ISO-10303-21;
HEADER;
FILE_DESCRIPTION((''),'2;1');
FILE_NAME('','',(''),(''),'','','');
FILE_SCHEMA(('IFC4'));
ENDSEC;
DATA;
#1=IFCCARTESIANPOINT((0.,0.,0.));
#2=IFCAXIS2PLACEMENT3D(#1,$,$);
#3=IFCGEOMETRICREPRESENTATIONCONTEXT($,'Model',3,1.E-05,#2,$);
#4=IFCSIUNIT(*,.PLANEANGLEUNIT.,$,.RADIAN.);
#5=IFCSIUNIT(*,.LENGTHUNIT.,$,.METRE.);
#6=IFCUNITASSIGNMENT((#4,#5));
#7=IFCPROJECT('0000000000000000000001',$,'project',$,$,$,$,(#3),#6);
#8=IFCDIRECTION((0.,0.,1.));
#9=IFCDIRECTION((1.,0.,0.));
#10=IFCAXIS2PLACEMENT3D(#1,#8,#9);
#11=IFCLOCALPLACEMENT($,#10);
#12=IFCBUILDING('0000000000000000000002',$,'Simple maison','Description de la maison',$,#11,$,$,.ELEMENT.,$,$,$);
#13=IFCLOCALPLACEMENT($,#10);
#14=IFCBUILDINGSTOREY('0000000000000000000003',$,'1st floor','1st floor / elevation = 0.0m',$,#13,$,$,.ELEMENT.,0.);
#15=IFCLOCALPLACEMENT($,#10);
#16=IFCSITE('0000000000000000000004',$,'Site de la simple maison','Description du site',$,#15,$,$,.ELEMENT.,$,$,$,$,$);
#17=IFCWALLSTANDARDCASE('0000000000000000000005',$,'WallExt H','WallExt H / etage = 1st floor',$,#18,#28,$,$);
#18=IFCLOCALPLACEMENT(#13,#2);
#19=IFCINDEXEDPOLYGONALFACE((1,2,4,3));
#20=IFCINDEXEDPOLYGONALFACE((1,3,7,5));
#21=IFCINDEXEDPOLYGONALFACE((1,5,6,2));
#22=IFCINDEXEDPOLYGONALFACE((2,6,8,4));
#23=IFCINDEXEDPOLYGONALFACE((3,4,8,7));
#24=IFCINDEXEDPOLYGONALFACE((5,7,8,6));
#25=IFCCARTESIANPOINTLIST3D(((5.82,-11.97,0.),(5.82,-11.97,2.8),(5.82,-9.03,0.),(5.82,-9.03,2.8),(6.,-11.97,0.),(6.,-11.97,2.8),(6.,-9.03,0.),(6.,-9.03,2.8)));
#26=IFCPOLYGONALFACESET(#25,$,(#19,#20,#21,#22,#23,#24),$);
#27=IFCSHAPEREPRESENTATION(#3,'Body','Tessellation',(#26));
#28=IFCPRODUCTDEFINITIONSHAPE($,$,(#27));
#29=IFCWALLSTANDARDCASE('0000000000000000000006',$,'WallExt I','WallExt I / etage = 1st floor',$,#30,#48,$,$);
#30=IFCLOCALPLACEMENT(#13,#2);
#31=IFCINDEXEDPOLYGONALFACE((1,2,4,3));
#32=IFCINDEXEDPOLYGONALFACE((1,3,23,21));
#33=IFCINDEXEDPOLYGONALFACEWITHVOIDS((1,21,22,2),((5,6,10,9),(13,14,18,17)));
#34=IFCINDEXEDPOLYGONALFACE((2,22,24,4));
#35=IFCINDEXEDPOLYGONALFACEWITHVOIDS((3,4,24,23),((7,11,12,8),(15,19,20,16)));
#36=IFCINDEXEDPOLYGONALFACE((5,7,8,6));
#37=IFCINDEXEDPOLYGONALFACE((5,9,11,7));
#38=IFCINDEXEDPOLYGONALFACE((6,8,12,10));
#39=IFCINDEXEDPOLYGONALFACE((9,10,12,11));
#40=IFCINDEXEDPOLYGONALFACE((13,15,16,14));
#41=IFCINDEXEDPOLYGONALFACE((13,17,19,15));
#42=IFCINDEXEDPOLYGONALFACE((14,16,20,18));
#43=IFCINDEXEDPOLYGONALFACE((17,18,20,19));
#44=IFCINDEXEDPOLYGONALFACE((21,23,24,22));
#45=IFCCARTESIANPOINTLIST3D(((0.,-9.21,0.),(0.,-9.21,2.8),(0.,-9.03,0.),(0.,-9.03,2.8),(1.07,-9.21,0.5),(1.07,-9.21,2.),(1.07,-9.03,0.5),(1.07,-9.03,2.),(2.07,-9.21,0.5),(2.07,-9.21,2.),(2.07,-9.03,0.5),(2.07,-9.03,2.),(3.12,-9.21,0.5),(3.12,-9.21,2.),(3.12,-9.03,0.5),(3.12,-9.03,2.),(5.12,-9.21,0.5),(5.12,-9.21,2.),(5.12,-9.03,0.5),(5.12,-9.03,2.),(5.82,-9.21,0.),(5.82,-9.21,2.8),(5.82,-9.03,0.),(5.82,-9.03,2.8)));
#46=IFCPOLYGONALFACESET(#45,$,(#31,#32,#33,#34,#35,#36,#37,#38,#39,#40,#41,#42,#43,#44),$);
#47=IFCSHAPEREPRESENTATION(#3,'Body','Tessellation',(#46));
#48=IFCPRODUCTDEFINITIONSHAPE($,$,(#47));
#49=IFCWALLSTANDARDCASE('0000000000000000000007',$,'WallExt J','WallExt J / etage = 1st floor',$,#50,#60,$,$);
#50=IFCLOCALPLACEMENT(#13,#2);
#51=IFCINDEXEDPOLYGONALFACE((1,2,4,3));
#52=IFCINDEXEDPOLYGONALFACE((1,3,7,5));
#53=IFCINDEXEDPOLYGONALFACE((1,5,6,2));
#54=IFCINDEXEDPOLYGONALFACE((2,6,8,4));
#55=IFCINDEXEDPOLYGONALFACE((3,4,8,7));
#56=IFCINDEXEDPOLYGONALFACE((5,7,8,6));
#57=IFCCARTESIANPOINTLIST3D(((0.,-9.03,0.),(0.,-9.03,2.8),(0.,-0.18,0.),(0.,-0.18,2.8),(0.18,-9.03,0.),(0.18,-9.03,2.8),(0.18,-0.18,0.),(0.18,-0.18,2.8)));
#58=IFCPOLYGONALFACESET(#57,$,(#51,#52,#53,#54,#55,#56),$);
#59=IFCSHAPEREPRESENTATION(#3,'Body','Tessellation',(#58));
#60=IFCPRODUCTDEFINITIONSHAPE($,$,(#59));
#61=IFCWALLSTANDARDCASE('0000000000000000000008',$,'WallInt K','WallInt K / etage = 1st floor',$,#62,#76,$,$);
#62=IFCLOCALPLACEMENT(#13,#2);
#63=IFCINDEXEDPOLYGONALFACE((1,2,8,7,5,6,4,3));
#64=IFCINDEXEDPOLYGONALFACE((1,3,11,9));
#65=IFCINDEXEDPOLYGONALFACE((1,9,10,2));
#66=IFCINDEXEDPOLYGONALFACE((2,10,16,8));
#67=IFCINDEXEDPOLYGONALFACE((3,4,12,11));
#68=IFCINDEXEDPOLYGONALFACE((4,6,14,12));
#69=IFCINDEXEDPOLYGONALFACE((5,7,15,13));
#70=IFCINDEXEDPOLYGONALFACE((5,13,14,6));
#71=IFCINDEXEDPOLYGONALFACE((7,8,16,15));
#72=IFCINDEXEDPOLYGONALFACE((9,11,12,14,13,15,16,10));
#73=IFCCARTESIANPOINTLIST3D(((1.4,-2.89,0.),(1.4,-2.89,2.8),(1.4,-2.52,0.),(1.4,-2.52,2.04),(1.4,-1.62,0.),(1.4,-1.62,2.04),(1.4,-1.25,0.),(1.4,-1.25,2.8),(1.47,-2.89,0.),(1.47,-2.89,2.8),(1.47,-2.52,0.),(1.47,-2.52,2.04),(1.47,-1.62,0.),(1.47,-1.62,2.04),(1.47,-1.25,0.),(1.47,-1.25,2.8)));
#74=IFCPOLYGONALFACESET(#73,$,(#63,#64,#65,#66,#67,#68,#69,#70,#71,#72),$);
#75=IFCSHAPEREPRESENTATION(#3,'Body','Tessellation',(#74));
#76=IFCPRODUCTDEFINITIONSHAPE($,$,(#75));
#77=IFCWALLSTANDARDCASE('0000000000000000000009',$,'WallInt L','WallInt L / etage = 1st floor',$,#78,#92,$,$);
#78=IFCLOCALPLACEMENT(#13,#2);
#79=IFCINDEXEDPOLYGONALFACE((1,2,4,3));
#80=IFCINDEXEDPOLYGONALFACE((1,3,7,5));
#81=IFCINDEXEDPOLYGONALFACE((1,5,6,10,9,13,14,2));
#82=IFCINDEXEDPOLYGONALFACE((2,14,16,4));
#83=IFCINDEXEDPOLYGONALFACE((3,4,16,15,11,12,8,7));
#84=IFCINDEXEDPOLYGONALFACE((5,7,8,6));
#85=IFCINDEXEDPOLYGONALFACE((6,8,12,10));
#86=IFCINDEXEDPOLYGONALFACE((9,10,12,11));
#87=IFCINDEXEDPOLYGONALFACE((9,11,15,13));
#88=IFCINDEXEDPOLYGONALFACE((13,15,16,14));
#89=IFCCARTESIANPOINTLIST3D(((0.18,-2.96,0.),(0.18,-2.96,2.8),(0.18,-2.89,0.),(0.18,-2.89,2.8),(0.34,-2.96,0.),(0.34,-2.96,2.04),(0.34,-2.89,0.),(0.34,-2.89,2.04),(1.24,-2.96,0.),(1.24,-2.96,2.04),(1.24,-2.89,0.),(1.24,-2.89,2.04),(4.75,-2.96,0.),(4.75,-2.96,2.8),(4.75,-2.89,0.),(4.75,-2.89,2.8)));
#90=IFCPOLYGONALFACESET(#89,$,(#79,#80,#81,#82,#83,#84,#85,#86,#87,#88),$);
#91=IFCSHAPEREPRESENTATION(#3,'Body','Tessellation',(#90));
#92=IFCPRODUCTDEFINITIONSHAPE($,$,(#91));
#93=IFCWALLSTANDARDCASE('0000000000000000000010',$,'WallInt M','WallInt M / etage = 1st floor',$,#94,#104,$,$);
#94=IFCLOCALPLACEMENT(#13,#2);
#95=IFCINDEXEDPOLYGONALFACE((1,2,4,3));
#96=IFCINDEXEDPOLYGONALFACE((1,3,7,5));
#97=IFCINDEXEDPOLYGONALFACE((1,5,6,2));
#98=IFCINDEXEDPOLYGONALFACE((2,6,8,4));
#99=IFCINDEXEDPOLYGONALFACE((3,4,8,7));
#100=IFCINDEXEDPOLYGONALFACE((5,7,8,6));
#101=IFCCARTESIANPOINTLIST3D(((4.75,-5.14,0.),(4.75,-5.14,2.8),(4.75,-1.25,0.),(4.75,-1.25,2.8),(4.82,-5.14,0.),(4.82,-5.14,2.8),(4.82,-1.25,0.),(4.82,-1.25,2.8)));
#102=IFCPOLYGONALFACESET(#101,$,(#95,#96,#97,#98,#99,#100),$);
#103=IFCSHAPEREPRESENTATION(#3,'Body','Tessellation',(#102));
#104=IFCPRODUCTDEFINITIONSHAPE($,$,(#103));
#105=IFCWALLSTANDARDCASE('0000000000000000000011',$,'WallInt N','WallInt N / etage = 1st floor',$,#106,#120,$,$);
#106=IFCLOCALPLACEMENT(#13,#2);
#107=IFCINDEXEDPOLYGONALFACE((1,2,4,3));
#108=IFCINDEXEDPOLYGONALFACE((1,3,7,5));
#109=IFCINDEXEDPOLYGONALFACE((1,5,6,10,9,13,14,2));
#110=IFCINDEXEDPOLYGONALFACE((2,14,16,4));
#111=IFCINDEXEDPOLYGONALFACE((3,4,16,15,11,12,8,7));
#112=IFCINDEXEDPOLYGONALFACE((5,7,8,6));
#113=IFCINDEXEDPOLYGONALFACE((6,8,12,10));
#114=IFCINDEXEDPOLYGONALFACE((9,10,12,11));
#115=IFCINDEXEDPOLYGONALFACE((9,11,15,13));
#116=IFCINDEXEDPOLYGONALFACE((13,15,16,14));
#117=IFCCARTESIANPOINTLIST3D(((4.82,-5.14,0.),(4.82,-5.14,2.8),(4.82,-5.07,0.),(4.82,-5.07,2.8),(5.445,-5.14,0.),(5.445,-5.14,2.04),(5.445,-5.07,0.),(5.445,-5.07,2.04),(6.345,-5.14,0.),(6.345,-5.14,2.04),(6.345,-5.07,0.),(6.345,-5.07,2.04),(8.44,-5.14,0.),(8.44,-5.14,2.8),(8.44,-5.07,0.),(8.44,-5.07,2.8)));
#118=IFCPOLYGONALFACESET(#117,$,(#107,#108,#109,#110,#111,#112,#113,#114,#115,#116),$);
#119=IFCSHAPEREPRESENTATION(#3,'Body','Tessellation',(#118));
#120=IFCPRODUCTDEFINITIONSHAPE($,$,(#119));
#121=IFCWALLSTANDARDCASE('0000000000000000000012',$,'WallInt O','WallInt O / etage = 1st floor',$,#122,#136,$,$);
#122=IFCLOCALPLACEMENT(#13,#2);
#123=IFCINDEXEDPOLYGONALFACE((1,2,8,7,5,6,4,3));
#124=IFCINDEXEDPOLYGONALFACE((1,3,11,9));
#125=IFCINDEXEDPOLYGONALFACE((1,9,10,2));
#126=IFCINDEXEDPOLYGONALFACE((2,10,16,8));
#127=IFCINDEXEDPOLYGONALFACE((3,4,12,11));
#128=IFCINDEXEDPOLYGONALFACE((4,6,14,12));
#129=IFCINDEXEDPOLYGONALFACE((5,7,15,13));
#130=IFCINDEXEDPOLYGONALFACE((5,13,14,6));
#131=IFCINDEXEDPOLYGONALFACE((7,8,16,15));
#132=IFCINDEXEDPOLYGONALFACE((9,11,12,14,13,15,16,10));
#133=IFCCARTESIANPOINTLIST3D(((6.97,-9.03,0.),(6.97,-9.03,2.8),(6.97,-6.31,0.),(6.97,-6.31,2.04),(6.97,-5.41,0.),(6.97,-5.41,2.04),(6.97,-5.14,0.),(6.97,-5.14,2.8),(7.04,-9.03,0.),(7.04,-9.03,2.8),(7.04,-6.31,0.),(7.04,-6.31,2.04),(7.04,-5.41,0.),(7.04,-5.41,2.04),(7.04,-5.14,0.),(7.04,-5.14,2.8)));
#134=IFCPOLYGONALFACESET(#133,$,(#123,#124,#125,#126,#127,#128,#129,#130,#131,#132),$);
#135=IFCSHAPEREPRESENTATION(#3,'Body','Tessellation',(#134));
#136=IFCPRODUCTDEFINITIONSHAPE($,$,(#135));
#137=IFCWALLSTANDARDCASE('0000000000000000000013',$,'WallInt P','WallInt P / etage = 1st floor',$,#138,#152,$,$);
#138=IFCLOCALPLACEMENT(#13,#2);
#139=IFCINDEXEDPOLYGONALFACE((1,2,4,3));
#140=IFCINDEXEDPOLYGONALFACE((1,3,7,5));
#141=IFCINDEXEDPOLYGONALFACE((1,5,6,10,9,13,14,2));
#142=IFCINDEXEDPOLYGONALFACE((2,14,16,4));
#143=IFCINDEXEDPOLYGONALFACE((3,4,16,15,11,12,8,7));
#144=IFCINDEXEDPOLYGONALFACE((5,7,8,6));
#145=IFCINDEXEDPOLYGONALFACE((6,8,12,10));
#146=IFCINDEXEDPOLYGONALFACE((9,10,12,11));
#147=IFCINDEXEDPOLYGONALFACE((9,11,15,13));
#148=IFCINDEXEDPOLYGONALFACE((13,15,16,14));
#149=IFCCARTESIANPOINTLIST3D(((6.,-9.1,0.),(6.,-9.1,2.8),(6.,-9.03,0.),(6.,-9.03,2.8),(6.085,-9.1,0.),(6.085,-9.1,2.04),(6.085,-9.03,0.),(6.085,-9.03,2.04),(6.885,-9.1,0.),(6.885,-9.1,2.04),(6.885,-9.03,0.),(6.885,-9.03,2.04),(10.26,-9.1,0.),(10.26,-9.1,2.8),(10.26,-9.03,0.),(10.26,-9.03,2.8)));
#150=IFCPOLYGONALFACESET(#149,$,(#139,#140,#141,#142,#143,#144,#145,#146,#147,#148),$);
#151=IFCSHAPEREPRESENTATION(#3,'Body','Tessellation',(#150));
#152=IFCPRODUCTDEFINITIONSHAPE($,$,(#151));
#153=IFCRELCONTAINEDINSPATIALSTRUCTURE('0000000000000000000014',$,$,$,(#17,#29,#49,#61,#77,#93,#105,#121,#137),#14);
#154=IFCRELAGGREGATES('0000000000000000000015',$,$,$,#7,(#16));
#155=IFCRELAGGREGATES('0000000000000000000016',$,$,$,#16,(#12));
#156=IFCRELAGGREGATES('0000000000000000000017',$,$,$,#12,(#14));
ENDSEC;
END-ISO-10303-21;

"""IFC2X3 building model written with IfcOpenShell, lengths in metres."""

from ifc_helpers import new_model, si_unit, frame, origin, origin_with_axes, origin_2d_with_axis, place, context, project, spatial, polyline, rectangle, outline, extrude, element, save


model = new_model("IFC2X3")

# Units and contexts
model_context = context("Model", 3, precision=1e-05, world=origin())
ifc_project = project(units=[si_unit("PLANEANGLEUNIT", "RADIAN"), si_unit("LENGTHUNIT", "METRE")], contexts=[model_context])

# Site, building, storey
site_placement = place(None, origin_with_axes())
site = spatial("IfcSite", under=ifc_project, at=site_placement, Name="Site de la simple maison", Description="Description du site", CompositionType="ELEMENT")
building_placement = place(None, origin_with_axes())
building = spatial("IfcBuilding", under=site, at=building_placement, Name="Simple maison", Description="Description de la maison", CompositionType="ELEMENT")
storey_placement = place(None, origin_with_axes())
storey = spatial("IfcBuildingStorey", under=building, at=storey_placement, Name="1st floor", Description="1st floor / elevation = 0.0m", CompositionType="ELEMENT", Elevation=0.0)

# Wall
wall_1_placement = place(storey_placement, frame((5.91, -11.97, 0.0), z_axis=(0.0, 0.0, 1.0), x_axis=(0.0, 1.0, 0.0)))
element("IfcWallStandardCase", 1, at=wall_1_placement, inside=storey, Name="WallExt H", Description="WallExt H / etage = 1st floor", context=model_context, shape_type="SweptSolid", body=[
    extrude(outline(polyline([(0.0, 0.09), (2.94, 0.09), (2.94, -0.09), (0.0, -0.09), (0.0, 0.09)])), origin(), (0.0, 0.0, 1.0), 2.8),
])

# Wall, openings
wall_2_placement = place(storey_placement, frame((5.82, -9.12, 0.0), z_axis=(0.0, 0.0, 1.0), x_axis=(-1.0, 0.0, 0.0)))
wall_2 = element("IfcWallStandardCase", 2, at=wall_2_placement, inside=storey, Name="WallExt I", Description="WallExt I / etage = 1st floor", context=model_context, shape_type="SweptSolid", body=[
    extrude(outline(polyline([(0.0, 0.09), (5.82, 0.09), (5.82, -0.09), (0.0, -0.09), (0.0, 0.09)])), origin(), (0.0, 0.0, 1.0), 2.8),
])
opening_1_placement = place(wall_2_placement, frame((3.75, -0.09, 0.5), z_axis=(0.0, 0.0, 1.0), x_axis=(1.0, 0.0, 0.0)))
element("IfcOpeningElement", 3, at=opening_1_placement, cuts=wall_2, context=model_context, shape_type="SweptSolid", body=[
    extrude(rectangle(XDim=1.5, YDim=1.0, at=origin_2d_with_axis()), frame((0.5, 0.0, 0.75), z_axis=(0.0, 1.0, 0.0), x_axis=(0.0, 0.0, 1.0)), (0.0, 0.0, 1.0), 0.18),
])
opening_2_placement = place(wall_2_placement, frame((0.7, -0.09, 0.5), z_axis=(0.0, 0.0, 1.0), x_axis=(1.0, 0.0, 0.0)))
element("IfcOpeningElement", 4, at=opening_2_placement, cuts=wall_2, context=model_context, shape_type="SweptSolid", body=[
    extrude(rectangle(XDim=1.5, YDim=2.0, at=origin_2d_with_axis()), frame((1.0, 0.0, 0.75), z_axis=(0.0, 1.0, 0.0), x_axis=(0.0, 0.0, 1.0)), (0.0, 0.0, 1.0), 0.18),
])

# Wall
wall_3_placement = place(storey_placement, frame((0.09, -9.03, 0.0), z_axis=(0.0, 0.0, 1.0), x_axis=(0.0, 1.0, 0.0)))
element("IfcWallStandardCase", 5, at=wall_3_placement, inside=storey, Name="WallExt J", Description="WallExt J / etage = 1st floor", context=model_context, shape_type="SweptSolid", body=[
    extrude(outline(polyline([(0.0, 0.09), (8.85, 0.09), (8.85, -0.09), (0.0, -0.09), (0.0, 0.09)])), origin(), (0.0, 0.0, 1.0), 2.8),
])

# Walls, openings
wall_4_placement = place(storey_placement, frame((1.435, -1.25, 0.0), z_axis=(0.0, 0.0, 1.0), x_axis=(0.0, -1.0, 0.0)))
wall_4 = element("IfcWallStandardCase", 6, at=wall_4_placement, inside=storey, Name="WallInt K", Description="WallInt K / etage = 1st floor", context=model_context, shape_type="SweptSolid", body=[
    extrude(outline(polyline([(0.0, 0.035), (1.64, 0.035), (1.64, -0.035), (0.0, -0.035), (0.0, 0.035)])), origin(), (0.0, 0.0, 1.0), 2.8),
])
opening_3_placement = place(wall_4_placement, frame((0.37, -0.035, 0.0), z_axis=(0.0, 0.0, 1.0), x_axis=(1.0, 0.0, 0.0)))
element("IfcOpeningElement", 7, at=opening_3_placement, cuts=wall_4, context=model_context, shape_type="SweptSolid", body=[
    extrude(rectangle(XDim=2.04, YDim=0.9, at=origin_2d_with_axis()), frame((0.45, 0.0, 1.02), z_axis=(0.0, 1.0, 0.0), x_axis=(0.0, 0.0, 1.0)), (0.0, 0.0, 1.0), 0.07),
])
wall_5_placement = place(storey_placement, frame((0.18, -2.925, 0.0), z_axis=(0.0, 0.0, 1.0), x_axis=(1.0, 0.0, 0.0)))
wall_5 = element("IfcWallStandardCase", 8, at=wall_5_placement, inside=storey, Name="WallInt L", Description="WallInt L / etage = 1st floor", context=model_context, shape_type="SweptSolid", body=[
    extrude(outline(polyline([(0.0, 0.035), (4.57, 0.035), (4.57, -0.035), (0.0, -0.035), (0.0, 0.035)])), origin(), (0.0, 0.0, 1.0), 2.8),
])
opening_4_placement = place(wall_5_placement, frame((0.16, -0.035, 0.0), z_axis=(0.0, 0.0, 1.0), x_axis=(1.0, 0.0, 0.0)))
element("IfcOpeningElement", 9, at=opening_4_placement, cuts=wall_5, context=model_context, shape_type="SweptSolid", body=[
    extrude(rectangle(XDim=2.04, YDim=0.9, at=origin_2d_with_axis()), frame((0.45, 0.0, 1.02), z_axis=(0.0, 1.0, 0.0), x_axis=(0.0, 0.0, 1.0)), (0.0, 0.0, 1.0), 0.07),
])

# Wall
wall_6_placement = place(storey_placement, frame((4.785, -1.25, 0.0), z_axis=(0.0, 0.0, 1.0), x_axis=(0.0, -1.0, 0.0)))
element("IfcWallStandardCase", 10, at=wall_6_placement, inside=storey, Name="WallInt M", Description="WallInt M / etage = 1st floor", context=model_context, shape_type="SweptSolid", body=[
    extrude(outline(polyline([(0.0, 0.035), (3.89, 0.035), (3.89, -0.035), (0.0, -0.035), (0.0, 0.035)])), origin(), (0.0, 0.0, 1.0), 2.8),
])

# Walls, openings
wall_7_placement = place(storey_placement, frame((4.82, -5.105, 0.0), z_axis=(0.0, 0.0, 1.0), x_axis=(1.0, 0.0, 0.0)))
wall_7 = element("IfcWallStandardCase", 11, at=wall_7_placement, inside=storey, Name="WallInt N", Description="WallInt N / etage = 1st floor", context=model_context, shape_type="SweptSolid", body=[
    extrude(outline(polyline([(0.0, 0.035), (3.62, 0.035), (3.62, -0.035), (0.0, -0.035), (0.0, 0.035)])), origin(), (0.0, 0.0, 1.0), 2.8),
])
opening_5_placement = place(wall_7_placement, frame((0.625, -0.035, 0.0), z_axis=(0.0, 0.0, 1.0), x_axis=(1.0, 0.0, 0.0)))
element("IfcOpeningElement", 12, at=opening_5_placement, cuts=wall_7, context=model_context, shape_type="SweptSolid", body=[
    extrude(rectangle(XDim=2.04, YDim=0.9, at=origin_2d_with_axis()), frame((0.45, 0.0, 1.02), z_axis=(0.0, 1.0, 0.0), x_axis=(0.0, 0.0, 1.0)), (0.0, 0.0, 1.0), 0.07),
])
wall_8_placement = place(storey_placement, frame((7.005, -5.14, 0.0), z_axis=(0.0, 0.0, 1.0), x_axis=(0.0, -1.0, 0.0)))
wall_8 = element("IfcWallStandardCase", 13, at=wall_8_placement, inside=storey, Name="WallInt O", Description="WallInt O / etage = 1st floor", context=model_context, shape_type="SweptSolid", body=[
    extrude(outline(polyline([(0.0, 0.035), (3.89, 0.035), (3.89, -0.035), (0.0, -0.035), (0.0, 0.035)])), origin(), (0.0, 0.0, 1.0), 2.8),
])
opening_6_placement = place(wall_8_placement, frame((0.27, -0.035, 0.0), z_axis=(0.0, 0.0, 1.0), x_axis=(1.0, 0.0, 0.0)))
element("IfcOpeningElement", 14, at=opening_6_placement, cuts=wall_8, context=model_context, shape_type="SweptSolid", body=[
    extrude(rectangle(XDim=2.04, YDim=0.9, at=origin_2d_with_axis()), frame((0.45, 0.0, 1.02), z_axis=(0.0, 1.0, 0.0), x_axis=(0.0, 0.0, 1.0)), (0.0, 0.0, 1.0), 0.07),
])
wall_9_placement = place(storey_placement, frame((6.0, -9.065, 0.0), z_axis=(0.0, 0.0, 1.0), x_axis=(1.0, 0.0, 0.0)))
wall_9 = element("IfcWallStandardCase", 15, at=wall_9_placement, inside=storey, Name="WallInt P", Description="WallInt P / etage = 1st floor", context=model_context, shape_type="SweptSolid", body=[
    extrude(outline(polyline([(0.0, 0.035), (4.26, 0.035), (4.26, -0.035), (0.0, -0.035), (0.0, 0.035)])), origin(), (0.0, 0.0, 1.0), 2.8),
])
opening_7_placement = place(wall_9_placement, frame((0.085, -0.035, 0.0), z_axis=(0.0, 0.0, 1.0), x_axis=(1.0, 0.0, 0.0)))
element("IfcOpeningElement", 16, at=opening_7_placement, cuts=wall_9, context=model_context, shape_type="SweptSolid", body=[
    extrude(rectangle(XDim=2.04, YDim=0.8, at=origin_2d_with_axis()), frame((0.4, 0.0, 1.02), z_axis=(0.0, 1.0, 0.0), x_axis=(0.0, 0.0, 1.0)), (0.0, 0.0, 1.0), 0.07),
])

save(model, "model.ifc")
